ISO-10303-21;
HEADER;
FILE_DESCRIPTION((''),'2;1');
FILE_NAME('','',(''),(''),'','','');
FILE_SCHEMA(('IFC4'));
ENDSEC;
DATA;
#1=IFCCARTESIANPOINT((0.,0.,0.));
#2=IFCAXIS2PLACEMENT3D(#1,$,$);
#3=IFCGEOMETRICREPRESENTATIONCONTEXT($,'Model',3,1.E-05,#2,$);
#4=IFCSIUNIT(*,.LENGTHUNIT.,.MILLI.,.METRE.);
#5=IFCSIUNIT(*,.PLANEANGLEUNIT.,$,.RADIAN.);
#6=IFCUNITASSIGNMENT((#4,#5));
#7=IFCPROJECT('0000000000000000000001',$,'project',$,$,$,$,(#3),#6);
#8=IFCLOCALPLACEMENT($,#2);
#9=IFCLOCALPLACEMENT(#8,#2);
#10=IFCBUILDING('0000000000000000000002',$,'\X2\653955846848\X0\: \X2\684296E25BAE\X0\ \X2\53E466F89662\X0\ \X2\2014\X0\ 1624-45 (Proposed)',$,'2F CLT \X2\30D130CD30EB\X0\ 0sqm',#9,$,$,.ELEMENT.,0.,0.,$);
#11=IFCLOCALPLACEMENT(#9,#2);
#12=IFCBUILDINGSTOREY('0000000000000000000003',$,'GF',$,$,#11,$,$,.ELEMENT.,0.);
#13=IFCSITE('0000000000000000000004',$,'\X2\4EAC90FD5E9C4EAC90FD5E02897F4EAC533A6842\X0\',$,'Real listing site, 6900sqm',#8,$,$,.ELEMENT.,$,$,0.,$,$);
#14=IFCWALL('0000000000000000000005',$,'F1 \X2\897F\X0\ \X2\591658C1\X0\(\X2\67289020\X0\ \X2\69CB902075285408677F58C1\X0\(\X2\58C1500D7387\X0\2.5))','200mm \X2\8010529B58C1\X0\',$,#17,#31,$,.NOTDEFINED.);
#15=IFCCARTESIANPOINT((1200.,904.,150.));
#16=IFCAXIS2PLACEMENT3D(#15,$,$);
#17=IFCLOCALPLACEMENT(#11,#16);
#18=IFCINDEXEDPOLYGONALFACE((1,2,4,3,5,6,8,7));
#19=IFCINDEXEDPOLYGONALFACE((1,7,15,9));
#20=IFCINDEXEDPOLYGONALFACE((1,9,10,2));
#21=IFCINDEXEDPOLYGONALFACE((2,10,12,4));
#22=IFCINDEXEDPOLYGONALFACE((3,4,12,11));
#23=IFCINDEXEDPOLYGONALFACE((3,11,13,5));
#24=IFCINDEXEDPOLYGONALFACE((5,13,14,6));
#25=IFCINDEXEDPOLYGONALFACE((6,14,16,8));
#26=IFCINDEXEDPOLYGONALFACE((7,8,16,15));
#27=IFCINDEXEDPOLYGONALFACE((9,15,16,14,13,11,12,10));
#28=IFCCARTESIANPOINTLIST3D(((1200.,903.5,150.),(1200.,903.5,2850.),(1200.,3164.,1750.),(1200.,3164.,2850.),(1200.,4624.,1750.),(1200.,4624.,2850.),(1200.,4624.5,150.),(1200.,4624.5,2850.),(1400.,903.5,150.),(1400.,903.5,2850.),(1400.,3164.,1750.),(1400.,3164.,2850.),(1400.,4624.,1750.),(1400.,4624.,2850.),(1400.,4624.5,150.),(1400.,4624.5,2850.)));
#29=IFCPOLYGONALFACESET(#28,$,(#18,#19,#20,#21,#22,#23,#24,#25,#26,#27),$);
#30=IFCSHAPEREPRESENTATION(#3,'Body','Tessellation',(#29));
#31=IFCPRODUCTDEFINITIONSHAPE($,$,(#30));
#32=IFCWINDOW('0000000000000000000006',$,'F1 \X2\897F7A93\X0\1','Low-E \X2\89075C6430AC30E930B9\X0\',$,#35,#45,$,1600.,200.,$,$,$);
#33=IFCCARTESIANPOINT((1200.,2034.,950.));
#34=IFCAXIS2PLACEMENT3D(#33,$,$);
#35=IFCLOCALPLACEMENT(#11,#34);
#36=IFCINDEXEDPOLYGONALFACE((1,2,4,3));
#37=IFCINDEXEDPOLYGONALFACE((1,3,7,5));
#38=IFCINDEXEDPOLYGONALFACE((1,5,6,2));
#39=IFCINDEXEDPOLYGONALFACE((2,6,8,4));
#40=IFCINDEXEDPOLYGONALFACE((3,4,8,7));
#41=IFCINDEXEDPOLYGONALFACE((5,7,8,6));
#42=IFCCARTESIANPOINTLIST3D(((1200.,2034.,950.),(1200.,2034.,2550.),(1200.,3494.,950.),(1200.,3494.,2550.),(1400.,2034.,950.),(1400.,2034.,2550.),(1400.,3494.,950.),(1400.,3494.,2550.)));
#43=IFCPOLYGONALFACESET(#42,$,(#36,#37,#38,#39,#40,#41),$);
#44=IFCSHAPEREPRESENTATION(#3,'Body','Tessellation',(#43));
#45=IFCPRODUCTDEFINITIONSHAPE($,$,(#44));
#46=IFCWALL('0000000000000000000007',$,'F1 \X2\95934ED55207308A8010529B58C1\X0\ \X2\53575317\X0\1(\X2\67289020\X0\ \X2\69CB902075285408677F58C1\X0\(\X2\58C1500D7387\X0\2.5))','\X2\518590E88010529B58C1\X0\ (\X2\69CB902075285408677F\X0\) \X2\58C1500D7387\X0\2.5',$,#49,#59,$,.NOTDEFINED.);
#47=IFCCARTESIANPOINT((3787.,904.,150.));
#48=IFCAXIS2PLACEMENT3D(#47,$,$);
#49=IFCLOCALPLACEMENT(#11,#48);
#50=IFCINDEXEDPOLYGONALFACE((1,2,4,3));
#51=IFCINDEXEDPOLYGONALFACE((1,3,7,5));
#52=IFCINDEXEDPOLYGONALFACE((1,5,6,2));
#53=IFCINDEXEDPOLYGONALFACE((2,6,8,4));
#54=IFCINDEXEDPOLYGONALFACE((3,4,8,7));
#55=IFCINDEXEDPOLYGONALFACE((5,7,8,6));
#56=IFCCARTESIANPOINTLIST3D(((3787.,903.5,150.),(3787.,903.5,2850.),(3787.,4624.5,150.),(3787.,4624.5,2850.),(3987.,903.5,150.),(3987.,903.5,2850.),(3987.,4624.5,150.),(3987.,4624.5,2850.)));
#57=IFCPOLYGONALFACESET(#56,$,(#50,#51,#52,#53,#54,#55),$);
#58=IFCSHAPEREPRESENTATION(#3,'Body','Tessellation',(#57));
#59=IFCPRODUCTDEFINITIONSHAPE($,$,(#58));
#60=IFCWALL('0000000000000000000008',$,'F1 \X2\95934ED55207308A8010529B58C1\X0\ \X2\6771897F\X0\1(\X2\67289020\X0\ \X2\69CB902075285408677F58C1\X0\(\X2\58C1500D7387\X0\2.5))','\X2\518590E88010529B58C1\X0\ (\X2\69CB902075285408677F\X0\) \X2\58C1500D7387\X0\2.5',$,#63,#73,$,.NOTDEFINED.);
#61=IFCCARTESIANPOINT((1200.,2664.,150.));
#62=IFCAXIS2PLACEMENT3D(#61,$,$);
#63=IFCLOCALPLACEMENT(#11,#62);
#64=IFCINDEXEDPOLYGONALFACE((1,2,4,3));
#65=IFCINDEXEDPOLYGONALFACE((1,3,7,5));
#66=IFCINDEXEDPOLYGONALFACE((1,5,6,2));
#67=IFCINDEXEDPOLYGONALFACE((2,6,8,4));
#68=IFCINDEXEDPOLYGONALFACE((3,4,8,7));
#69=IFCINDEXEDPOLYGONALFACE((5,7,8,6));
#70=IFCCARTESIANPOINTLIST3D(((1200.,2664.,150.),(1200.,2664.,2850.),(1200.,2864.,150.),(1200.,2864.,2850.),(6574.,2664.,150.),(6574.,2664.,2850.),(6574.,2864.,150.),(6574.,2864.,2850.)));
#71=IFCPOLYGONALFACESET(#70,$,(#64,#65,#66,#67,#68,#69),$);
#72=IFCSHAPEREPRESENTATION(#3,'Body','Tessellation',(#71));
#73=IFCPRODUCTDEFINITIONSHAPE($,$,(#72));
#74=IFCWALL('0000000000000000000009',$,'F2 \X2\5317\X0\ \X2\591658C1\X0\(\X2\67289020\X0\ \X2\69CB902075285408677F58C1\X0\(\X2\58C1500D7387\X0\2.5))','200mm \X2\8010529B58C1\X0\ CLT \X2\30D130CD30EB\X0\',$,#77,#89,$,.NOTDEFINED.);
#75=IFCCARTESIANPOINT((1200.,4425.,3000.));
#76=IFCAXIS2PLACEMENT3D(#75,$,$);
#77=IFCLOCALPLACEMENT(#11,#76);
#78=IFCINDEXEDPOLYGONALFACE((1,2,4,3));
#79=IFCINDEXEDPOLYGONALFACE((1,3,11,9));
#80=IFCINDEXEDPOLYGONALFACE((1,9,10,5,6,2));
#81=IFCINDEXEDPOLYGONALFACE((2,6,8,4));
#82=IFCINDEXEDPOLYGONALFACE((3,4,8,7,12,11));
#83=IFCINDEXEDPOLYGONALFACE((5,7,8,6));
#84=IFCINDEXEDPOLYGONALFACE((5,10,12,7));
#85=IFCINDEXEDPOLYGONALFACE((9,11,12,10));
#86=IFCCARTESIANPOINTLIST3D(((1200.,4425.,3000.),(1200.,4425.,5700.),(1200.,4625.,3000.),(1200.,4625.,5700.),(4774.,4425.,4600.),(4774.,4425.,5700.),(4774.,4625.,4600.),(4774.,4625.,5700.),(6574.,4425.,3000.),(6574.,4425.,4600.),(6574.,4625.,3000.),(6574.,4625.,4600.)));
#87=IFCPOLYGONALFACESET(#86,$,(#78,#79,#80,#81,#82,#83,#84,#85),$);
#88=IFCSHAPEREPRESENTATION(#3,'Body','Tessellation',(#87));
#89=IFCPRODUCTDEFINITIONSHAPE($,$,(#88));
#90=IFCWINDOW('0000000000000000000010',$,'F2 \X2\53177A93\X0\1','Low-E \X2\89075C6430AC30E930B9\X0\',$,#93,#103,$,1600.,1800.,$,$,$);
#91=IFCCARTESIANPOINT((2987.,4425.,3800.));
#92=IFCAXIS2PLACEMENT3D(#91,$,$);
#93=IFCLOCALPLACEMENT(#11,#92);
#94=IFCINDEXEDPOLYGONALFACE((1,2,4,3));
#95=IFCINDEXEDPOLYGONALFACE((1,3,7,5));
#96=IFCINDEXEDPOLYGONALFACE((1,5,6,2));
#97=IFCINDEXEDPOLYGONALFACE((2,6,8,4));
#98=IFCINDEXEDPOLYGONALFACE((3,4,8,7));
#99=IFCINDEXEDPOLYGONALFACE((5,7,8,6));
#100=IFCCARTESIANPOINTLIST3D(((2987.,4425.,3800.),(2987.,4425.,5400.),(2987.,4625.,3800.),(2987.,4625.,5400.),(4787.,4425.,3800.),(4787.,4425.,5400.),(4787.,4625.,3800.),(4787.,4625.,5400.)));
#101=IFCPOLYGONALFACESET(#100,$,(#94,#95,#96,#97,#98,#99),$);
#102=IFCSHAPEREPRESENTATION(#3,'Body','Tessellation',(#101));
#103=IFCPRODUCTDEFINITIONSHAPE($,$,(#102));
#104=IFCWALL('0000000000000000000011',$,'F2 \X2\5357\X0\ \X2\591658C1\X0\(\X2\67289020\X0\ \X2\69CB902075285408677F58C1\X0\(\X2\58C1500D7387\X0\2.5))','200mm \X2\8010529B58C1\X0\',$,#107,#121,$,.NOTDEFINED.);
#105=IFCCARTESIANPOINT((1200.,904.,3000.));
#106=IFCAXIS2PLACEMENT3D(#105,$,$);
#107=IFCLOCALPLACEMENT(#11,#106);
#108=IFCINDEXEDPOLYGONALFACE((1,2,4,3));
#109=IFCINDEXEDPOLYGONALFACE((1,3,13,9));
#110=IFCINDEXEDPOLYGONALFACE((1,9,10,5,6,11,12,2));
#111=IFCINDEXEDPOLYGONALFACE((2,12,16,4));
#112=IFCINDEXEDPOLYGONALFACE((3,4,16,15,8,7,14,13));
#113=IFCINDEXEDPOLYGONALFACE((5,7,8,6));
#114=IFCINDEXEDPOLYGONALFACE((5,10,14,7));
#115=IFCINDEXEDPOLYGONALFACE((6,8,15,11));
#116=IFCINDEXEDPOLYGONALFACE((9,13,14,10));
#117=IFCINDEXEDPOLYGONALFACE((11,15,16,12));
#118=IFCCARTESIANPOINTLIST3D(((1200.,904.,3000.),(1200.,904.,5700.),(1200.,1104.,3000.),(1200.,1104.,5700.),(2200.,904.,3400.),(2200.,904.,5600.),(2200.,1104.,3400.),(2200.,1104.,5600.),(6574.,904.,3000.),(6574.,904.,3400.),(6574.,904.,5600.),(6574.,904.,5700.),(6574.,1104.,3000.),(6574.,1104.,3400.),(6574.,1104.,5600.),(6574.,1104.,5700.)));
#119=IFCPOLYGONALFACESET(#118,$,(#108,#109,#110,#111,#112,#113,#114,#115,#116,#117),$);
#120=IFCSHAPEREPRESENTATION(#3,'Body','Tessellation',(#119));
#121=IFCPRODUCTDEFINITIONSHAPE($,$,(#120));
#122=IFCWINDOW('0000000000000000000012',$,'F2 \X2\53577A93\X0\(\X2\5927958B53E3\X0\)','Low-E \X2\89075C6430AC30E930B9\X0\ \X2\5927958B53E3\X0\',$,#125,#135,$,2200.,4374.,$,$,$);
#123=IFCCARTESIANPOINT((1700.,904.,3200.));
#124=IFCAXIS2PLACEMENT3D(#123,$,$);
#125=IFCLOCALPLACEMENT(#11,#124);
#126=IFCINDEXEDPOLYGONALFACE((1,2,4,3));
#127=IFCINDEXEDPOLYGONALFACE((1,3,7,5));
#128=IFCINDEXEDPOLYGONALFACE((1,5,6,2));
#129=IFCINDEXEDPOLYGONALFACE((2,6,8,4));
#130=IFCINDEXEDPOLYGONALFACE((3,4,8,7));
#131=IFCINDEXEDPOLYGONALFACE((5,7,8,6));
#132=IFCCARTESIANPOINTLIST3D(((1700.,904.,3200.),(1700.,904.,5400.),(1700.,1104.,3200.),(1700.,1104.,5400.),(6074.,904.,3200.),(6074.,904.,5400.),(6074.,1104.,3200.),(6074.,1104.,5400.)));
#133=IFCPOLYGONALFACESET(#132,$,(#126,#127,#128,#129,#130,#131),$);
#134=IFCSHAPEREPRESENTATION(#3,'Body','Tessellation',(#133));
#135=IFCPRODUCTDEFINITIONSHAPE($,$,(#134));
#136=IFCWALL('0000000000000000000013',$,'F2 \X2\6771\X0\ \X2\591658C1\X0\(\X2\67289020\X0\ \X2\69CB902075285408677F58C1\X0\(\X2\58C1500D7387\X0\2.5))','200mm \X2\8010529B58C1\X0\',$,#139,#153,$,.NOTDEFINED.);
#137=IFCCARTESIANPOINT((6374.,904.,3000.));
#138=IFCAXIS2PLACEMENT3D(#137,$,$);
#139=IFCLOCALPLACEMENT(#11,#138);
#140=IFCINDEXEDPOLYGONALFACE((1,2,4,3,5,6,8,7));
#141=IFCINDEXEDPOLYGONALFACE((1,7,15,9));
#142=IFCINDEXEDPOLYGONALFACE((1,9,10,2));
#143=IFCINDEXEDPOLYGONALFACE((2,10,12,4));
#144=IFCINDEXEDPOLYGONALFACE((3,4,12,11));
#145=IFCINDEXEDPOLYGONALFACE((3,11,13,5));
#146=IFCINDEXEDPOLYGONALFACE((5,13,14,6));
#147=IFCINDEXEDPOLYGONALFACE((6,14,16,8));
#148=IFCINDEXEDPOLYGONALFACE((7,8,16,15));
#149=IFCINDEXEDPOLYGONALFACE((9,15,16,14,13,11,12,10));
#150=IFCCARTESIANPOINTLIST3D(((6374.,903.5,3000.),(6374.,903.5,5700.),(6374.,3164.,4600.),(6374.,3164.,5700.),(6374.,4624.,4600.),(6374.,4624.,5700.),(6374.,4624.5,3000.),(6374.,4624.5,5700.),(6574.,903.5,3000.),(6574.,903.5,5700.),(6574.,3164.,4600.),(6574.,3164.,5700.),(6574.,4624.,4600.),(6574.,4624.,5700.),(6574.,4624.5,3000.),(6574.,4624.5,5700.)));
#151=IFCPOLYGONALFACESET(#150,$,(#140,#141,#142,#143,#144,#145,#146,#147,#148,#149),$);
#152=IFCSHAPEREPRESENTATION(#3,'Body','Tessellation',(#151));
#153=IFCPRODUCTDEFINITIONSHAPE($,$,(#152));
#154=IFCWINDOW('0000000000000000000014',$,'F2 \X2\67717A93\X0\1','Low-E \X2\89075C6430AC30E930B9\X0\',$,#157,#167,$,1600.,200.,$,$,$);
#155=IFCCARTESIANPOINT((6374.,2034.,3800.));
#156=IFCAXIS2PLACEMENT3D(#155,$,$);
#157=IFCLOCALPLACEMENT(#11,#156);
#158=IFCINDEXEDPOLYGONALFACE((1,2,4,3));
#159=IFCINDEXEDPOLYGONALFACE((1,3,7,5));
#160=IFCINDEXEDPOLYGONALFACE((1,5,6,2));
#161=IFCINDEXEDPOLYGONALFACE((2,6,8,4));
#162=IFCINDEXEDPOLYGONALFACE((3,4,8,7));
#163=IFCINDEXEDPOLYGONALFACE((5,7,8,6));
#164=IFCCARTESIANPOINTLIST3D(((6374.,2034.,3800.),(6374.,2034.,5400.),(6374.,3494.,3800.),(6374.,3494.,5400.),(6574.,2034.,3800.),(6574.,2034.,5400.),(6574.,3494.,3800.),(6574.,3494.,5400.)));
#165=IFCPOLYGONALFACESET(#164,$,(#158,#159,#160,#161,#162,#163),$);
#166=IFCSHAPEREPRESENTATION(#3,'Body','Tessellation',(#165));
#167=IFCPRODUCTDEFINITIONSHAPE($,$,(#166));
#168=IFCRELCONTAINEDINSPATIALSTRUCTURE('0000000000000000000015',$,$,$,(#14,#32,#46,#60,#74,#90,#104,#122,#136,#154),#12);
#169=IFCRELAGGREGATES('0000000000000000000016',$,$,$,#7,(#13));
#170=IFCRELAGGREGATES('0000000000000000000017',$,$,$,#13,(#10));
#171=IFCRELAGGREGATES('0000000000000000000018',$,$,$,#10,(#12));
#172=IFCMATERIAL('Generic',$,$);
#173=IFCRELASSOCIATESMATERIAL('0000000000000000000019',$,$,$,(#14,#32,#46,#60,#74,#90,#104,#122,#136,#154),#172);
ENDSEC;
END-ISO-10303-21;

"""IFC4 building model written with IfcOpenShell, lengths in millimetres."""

from ifc_helpers import new_model, si_unit, frame, frame_2d, origin, place, context, project, spatial, rectangle, extrude, material, element, fill, save


model = new_model("IFC4")

# Units and contexts
model_context = context("Model", 3, precision=1e-05, world=origin())
ifc_project = project(units=[si_unit("LENGTHUNIT", "METRE", prefix="MILLI"), si_unit("PLANEANGLEUNIT", "RADIAN")], contexts=[model_context])

# Site, building, storey
site_placement = place(None, origin())
site = spatial("IfcSite", under=ifc_project, at=site_placement, Name="京都府京都市西京区桂", ObjectType="Real listing site, 6900sqm", CompositionType="ELEMENT", RefElevation=0.0)
building_placement = place(site_placement, origin())
building = spatial("IfcBuilding", under=site, at=building_placement, Name="改善案: 桂離宮 古書院 — 1624-45 (Proposed)", ObjectType="2F CLT パネル 0sqm", CompositionType="ELEMENT", ElevationOfRefHeight=0.0, ElevationOfTerrain=0.0)
storey_placement = place(building_placement, origin())
storey = spatial("IfcBuildingStorey", under=building, at=storey_placement, Name="GF", CompositionType="ELEMENT", Elevation=0.0)

# Shared definitions
ifc_material_1 = material(Name="Generic")

# Wall, opening, window
wall_1_placement = place(storey_placement, frame((1200.0, 904.0, 150.0)))
wall_1 = element("IfcWall", 1, at=wall_1_placement, inside=storey, material=ifc_material_1, Name="F1 西 外壁(木造 構造用合板壁(壁倍率2.5))", Description="200mm 耐力壁", PredefinedType="NOTDEFINED", context=model_context, shape_type="SweptSolid", body=[
    extrude(rectangle(XDim=200.0, YDim=3721.0, at=frame_2d((100.0, 1860.0))), frame((1200.0, 904.0, 150.0)), (0.0, 0.0, 1.0), 2700.0),
])
opening_1_placement = place(storey_placement, frame((1200.0, 2034.0, 950.0)))
opening_1 = element("IfcOpeningElement", 2, at=opening_1_placement, cuts=wall_1, PredefinedType="NOTDEFINED", context=model_context, shape_type="SweptSolid", body=[
    extrude(rectangle(XDim=200.0, YDim=1460.0, at=frame_2d((100.0, 730.0))), frame((1200.0, 2034.0, 950.0)), (0.0, 0.0, 1.0), 1600.0),
])
window_1_placement = place(storey_placement, frame((1200.0, 2034.0, 950.0)))
window_1 = element("IfcWindow", 3, at=window_1_placement, inside=storey, material=ifc_material_1, Name="F1 西窓1", Description="Low-E 複層ガラス", OverallHeight=1600.0, OverallWidth=200.0, context=model_context, shape_type="SweptSolid", body=[
    extrude(rectangle(XDim=200.0, YDim=1460.0, at=frame_2d((100.0, 730.0))), frame((1200.0, 2034.0, 950.0)), (0.0, 0.0, 1.0), 1600.0),
])
fill(opening_1, window_1)

# Walls
wall_2_placement = place(storey_placement, frame((3787.0, 904.0, 150.0)))
element("IfcWall", 4, at=wall_2_placement, inside=storey, material=ifc_material_1, Name="F1 間仕切り耐力壁 南北1(木造 構造用合板壁(壁倍率2.5))", Description="内部耐力壁 (構造用合板) 壁倍率2.5", PredefinedType="NOTDEFINED", context=model_context, shape_type="SweptSolid", body=[
    extrude(rectangle(XDim=200.0, YDim=3721.0, at=frame_2d((100.0, 1860.0))), frame((3787.0, 904.0, 150.0)), (0.0, 0.0, 1.0), 2700.0),
])
wall_3_placement = place(storey_placement, frame((1200.0, 2664.0, 150.0)))
element("IfcWall", 5, at=wall_3_placement, inside=storey, material=ifc_material_1, Name="F1 間仕切り耐力壁 東西1(木造 構造用合板壁(壁倍率2.5))", Description="内部耐力壁 (構造用合板) 壁倍率2.5", PredefinedType="NOTDEFINED", context=model_context, shape_type="SweptSolid", body=[
    extrude(rectangle(XDim=5374.0, YDim=200.0, at=frame_2d((2687.0, 100.0))), frame((1200.0, 2664.0, 150.0)), (0.0, 0.0, 1.0), 2700.0),
])

# Walls, openings, windows
wall_4_placement = place(storey_placement, frame((1200.0, 4425.0, 3000.0)))
wall_4 = element("IfcWall", 6, at=wall_4_placement, inside=storey, material=ifc_material_1, Name="F2 北 外壁(木造 構造用合板壁(壁倍率2.5))", Description="200mm 耐力壁 CLT パネル", PredefinedType="NOTDEFINED", context=model_context, shape_type="SweptSolid", body=[
    extrude(rectangle(XDim=5374.0, YDim=200.0, at=frame_2d((2687.0, 100.0))), frame((1200.0, 4425.0, 3000.0)), (0.0, 0.0, 1.0), 2700.0),
])
opening_2_placement = place(storey_placement, frame((2987.0, 4425.0, 3800.0)))
opening_2 = element("IfcOpeningElement", 7, at=opening_2_placement, cuts=wall_4, PredefinedType="NOTDEFINED", context=model_context, shape_type="SweptSolid", body=[
    extrude(rectangle(XDim=1800.0, YDim=200.0, at=frame_2d((900.0, 100.0))), frame((2987.0, 4425.0, 3800.0)), (0.0, 0.0, 1.0), 1600.0),
])
window_2_placement = place(storey_placement, frame((2987.0, 4425.0, 3800.0)))
window_2 = element("IfcWindow", 8, at=window_2_placement, inside=storey, material=ifc_material_1, Name="F2 北窓1", Description="Low-E 複層ガラス", OverallHeight=1600.0, OverallWidth=1800.0, context=model_context, shape_type="SweptSolid", body=[
    extrude(rectangle(XDim=1800.0, YDim=200.0, at=frame_2d((900.0, 100.0))), frame((2987.0, 4425.0, 3800.0)), (0.0, 0.0, 1.0), 1600.0),
])
fill(opening_2, window_2)
wall_5_placement = place(storey_placement, frame((1200.0, 904.0, 3000.0)))
wall_5 = element("IfcWall", 9, at=wall_5_placement, inside=storey, material=ifc_material_1, Name="F2 南 外壁(木造 構造用合板壁(壁倍率2.5))", Description="200mm 耐力壁", PredefinedType="NOTDEFINED", context=model_context, shape_type="SweptSolid", body=[
    extrude(rectangle(XDim=5374.0, YDim=200.0, at=frame_2d((2687.0, 100.0))), frame((1200.0, 904.0, 3000.0)), (0.0, 0.0, 1.0), 2700.0),
])
opening_3_placement = place(storey_placement, frame((1700.0, 904.0, 3200.0)))
opening_3 = element("IfcOpeningElement", 10, at=opening_3_placement, cuts=wall_5, PredefinedType="NOTDEFINED", context=model_context, shape_type="SweptSolid", body=[
    extrude(rectangle(XDim=4374.0, YDim=200.0, at=frame_2d((2187.0, 100.0))), frame((1700.0, 904.0, 3200.0)), (0.0, 0.0, 1.0), 2200.0),
])
window_3_placement = place(storey_placement, frame((1700.0, 904.0, 3200.0)))
window_3 = element("IfcWindow", 11, at=window_3_placement, inside=storey, material=ifc_material_1, Name="F2 南窓(大開口)", Description="Low-E 複層ガラス 大開口", OverallHeight=2200.0, OverallWidth=4374.0, context=model_context, shape_type="SweptSolid", body=[
    extrude(rectangle(XDim=4374.0, YDim=200.0, at=frame_2d((2187.0, 100.0))), frame((1700.0, 904.0, 3200.0)), (0.0, 0.0, 1.0), 2200.0),
])
fill(opening_3, window_3)
wall_6_placement = place(storey_placement, frame((6374.0, 904.0, 3000.0)))
wall_6 = element("IfcWall", 12, at=wall_6_placement, inside=storey, material=ifc_material_1, Name="F2 東 外壁(木造 構造用合板壁(壁倍率2.5))", Description="200mm 耐力壁", PredefinedType="NOTDEFINED", context=model_context, shape_type="SweptSolid", body=[
    extrude(rectangle(XDim=200.0, YDim=3721.0, at=frame_2d((100.0, 1860.0))), frame((6374.0, 904.0, 3000.0)), (0.0, 0.0, 1.0), 2700.0),
])
opening_4_placement = place(storey_placement, frame((6374.0, 2034.0, 3800.0)))
opening_4 = element("IfcOpeningElement", 13, at=opening_4_placement, cuts=wall_6, PredefinedType="NOTDEFINED", context=model_context, shape_type="SweptSolid", body=[
    extrude(rectangle(XDim=200.0, YDim=1460.0, at=frame_2d((100.0, 730.0))), frame((6374.0, 2034.0, 3800.0)), (0.0, 0.0, 1.0), 1600.0),
])
window_4_placement = place(storey_placement, frame((6374.0, 2034.0, 3800.0)))
window_4 = element("IfcWindow", 14, at=window_4_placement, inside=storey, material=ifc_material_1, Name="F2 東窓1", Description="Low-E 複層ガラス", OverallHeight=1600.0, OverallWidth=200.0, context=model_context, shape_type="SweptSolid", body=[
    extrude(rectangle(XDim=200.0, YDim=1460.0, at=frame_2d((100.0, 730.0))), frame((6374.0, 2034.0, 3800.0)), (0.0, 0.0, 1.0), 1600.0),
])
fill(opening_4, window_4)

save(model, "model.ifc")
